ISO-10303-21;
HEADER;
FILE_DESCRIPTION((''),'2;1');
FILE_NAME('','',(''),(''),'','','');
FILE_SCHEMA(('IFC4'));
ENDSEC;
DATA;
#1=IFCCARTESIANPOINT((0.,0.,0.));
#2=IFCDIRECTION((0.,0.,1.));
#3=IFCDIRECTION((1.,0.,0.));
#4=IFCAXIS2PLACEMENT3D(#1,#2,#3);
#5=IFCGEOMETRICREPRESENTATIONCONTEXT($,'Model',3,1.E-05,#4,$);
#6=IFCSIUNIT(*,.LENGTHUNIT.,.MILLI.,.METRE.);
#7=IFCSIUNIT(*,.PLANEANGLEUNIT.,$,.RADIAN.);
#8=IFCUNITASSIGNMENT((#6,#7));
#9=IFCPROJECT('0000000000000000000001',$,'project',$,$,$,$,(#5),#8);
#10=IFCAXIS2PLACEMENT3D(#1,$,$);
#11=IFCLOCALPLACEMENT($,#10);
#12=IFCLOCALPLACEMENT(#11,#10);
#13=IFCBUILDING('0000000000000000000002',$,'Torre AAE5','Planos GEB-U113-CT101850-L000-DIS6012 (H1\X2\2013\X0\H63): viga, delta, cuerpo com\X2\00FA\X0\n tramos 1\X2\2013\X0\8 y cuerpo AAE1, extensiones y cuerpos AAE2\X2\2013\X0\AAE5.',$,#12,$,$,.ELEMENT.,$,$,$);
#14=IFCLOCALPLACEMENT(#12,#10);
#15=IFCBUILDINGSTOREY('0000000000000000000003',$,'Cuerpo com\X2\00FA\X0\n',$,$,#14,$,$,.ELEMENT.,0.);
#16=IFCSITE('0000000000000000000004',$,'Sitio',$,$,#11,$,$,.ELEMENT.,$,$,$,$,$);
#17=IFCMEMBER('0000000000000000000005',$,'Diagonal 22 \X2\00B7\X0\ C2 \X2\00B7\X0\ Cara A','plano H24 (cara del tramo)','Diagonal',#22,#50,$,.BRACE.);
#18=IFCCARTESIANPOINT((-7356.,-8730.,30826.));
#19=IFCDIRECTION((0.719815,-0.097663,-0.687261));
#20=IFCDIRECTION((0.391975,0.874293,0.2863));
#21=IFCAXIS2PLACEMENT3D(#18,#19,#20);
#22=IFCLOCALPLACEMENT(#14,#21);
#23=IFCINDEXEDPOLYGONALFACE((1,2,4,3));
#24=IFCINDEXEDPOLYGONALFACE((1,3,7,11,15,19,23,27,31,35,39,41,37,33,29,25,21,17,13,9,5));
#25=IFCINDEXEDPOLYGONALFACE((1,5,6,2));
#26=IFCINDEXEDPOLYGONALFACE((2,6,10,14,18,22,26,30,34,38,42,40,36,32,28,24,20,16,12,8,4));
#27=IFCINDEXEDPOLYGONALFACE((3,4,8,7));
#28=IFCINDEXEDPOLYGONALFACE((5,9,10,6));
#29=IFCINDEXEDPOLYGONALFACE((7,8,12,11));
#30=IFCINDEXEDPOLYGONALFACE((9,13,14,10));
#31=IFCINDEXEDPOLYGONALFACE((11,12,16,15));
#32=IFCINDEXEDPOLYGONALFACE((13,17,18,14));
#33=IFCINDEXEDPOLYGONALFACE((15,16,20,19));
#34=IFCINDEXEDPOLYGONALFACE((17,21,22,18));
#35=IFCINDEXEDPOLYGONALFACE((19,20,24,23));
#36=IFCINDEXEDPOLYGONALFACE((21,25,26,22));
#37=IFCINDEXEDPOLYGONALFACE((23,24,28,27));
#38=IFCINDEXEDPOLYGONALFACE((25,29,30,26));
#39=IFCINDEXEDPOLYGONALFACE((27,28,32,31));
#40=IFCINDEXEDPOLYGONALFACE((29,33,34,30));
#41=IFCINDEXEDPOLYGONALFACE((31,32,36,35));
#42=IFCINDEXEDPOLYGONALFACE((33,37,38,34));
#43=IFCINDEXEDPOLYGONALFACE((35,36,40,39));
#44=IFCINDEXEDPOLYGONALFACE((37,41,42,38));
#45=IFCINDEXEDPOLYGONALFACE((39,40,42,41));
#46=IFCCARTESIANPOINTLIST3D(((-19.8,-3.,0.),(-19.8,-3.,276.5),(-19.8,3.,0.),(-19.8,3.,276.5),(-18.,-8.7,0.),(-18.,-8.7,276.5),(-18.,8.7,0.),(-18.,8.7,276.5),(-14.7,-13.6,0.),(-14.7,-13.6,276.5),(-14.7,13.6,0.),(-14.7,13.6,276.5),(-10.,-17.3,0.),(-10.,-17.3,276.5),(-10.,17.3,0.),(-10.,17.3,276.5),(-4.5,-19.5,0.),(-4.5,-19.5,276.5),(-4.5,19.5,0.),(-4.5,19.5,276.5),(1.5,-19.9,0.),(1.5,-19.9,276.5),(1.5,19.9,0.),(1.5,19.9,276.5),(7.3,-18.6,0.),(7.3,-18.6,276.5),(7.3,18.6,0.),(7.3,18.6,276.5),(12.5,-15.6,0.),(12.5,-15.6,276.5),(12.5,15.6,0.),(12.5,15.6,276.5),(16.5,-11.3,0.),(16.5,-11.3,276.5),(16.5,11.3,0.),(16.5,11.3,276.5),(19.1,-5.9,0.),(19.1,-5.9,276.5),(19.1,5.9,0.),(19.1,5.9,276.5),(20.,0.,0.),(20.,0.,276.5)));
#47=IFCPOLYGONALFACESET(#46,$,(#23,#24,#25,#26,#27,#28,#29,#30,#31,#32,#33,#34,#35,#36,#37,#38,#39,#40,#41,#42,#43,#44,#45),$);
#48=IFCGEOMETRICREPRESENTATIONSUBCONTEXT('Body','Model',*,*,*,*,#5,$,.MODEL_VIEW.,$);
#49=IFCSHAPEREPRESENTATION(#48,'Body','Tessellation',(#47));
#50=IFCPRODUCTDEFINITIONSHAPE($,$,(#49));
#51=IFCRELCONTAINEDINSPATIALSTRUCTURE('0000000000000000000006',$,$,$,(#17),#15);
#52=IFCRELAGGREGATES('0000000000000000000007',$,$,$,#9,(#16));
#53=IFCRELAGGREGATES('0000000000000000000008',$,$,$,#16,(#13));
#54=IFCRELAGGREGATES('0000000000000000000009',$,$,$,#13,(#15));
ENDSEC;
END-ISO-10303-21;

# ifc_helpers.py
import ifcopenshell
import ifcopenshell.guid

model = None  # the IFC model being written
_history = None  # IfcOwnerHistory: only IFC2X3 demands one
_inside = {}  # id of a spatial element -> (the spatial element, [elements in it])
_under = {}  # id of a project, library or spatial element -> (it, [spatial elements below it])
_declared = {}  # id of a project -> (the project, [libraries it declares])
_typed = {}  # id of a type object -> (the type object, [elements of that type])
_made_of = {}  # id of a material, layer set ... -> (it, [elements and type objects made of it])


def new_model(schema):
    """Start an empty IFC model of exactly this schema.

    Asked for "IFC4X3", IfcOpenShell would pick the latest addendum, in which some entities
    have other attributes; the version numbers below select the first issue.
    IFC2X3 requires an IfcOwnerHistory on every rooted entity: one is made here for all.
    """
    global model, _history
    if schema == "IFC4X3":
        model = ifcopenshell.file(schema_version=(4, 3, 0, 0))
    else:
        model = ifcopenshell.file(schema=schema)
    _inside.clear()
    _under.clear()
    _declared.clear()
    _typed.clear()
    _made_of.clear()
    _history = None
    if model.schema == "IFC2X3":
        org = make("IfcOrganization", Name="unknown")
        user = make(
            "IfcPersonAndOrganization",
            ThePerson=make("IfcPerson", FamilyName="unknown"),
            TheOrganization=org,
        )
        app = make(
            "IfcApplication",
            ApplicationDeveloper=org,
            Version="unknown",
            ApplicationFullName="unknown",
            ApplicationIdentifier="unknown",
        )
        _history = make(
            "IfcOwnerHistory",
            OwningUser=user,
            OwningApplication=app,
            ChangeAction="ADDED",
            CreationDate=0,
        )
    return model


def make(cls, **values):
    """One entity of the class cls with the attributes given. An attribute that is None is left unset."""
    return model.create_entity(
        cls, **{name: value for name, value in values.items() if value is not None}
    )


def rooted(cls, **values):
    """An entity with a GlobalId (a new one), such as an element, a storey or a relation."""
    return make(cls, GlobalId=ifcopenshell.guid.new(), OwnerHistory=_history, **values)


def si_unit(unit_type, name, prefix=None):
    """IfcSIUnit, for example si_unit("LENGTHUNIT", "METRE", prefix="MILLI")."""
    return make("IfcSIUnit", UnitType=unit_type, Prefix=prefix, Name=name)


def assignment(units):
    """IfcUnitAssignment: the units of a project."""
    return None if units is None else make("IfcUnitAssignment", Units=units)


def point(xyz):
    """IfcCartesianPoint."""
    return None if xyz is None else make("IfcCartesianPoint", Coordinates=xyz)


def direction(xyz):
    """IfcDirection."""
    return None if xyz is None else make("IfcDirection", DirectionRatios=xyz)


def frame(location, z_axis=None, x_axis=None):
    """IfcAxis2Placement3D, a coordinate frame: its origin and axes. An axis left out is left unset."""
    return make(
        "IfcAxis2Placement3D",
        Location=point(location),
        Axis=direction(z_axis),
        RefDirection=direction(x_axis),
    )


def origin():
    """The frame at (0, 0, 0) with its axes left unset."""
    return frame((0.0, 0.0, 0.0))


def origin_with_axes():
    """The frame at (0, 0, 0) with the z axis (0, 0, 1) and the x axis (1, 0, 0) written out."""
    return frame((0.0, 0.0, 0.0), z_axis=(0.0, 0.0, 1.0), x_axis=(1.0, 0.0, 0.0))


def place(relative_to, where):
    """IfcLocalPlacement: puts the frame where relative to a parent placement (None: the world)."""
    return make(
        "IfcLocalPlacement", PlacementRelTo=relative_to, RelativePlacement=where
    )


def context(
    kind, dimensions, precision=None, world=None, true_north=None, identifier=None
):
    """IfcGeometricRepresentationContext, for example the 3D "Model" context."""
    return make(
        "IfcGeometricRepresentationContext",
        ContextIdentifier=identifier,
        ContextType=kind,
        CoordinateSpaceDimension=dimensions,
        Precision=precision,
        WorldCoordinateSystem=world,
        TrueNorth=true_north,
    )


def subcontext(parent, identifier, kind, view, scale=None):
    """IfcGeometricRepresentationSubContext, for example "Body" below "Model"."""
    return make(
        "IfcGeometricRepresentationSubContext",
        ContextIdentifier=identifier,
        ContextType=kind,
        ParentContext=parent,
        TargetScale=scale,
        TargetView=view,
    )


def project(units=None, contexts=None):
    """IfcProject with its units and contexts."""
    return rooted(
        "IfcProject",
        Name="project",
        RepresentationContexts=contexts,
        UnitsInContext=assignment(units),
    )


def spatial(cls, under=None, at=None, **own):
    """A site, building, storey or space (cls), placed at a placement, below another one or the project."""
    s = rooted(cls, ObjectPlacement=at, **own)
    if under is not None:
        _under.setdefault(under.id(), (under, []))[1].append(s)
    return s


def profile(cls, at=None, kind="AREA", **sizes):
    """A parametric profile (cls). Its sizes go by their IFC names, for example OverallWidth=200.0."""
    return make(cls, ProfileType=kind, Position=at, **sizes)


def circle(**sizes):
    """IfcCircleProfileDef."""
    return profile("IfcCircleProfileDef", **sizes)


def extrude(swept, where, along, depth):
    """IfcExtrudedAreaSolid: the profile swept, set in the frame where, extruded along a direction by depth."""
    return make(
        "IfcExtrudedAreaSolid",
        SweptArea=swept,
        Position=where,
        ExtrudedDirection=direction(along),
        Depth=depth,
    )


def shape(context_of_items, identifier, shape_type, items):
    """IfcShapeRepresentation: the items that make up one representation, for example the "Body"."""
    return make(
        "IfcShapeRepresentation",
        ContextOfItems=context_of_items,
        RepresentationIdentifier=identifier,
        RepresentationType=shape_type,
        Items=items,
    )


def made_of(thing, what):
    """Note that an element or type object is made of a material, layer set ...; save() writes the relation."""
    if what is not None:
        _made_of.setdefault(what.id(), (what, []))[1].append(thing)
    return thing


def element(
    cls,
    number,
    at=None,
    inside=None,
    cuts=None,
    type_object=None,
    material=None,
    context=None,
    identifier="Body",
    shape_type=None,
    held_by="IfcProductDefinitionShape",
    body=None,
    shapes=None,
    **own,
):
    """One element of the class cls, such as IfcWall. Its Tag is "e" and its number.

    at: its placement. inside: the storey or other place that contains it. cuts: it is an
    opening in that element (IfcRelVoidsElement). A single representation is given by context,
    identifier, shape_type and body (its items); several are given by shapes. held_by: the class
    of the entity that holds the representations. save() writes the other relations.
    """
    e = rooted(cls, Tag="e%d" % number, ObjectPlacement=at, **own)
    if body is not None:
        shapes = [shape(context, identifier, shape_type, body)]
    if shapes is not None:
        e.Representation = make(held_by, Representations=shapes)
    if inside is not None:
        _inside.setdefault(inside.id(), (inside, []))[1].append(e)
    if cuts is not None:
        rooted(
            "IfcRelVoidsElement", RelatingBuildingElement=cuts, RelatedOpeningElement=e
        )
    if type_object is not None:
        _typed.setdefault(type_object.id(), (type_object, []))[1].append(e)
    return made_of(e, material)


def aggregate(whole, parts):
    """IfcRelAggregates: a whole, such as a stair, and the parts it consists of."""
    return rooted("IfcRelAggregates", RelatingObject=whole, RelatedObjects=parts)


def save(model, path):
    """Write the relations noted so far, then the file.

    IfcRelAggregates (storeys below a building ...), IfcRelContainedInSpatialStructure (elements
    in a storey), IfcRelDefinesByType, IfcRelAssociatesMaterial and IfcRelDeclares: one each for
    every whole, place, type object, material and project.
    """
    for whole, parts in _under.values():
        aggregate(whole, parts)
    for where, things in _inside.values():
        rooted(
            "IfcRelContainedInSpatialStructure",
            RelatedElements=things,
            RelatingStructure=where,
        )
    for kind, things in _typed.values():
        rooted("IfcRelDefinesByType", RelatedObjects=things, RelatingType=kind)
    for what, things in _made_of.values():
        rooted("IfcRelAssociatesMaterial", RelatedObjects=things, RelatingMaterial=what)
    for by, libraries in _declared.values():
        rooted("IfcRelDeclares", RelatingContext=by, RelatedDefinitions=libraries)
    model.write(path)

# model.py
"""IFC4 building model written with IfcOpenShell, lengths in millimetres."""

from ifc_helpers import new_model, si_unit, frame, origin, origin_with_axes, place, context, subcontext, project, spatial, circle, extrude, element, save


model = new_model("IFC4")

# Units and contexts
model_context = context("Model", 3, precision=1e-05, world=origin_with_axes())
body_context = subcontext(model_context, "Body", "Model", "MODEL_VIEW")
ifc_project = project(units=[si_unit("LENGTHUNIT", "METRE", prefix="MILLI"), si_unit("PLANEANGLEUNIT", "RADIAN")], contexts=[model_context])

# Site, building, storey
site_placement = place(None, origin())
site = spatial("IfcSite", under=ifc_project, at=site_placement, Name="Sitio", CompositionType="ELEMENT")
building_placement = place(site_placement, origin())
building = spatial("IfcBuilding", under=site, at=building_placement, Name="Torre AAE5", Description="Planos GEB-U113-CT101850-L000-DIS6012 (H1–H63): viga, delta, cuerpo común tramos 1–8 y cuerpo AAE1, extensiones y cuerpos AAE2–AAE5.", CompositionType="ELEMENT")
storey_placement = place(building_placement, origin())
storey = spatial("IfcBuildingStorey", under=building, at=storey_placement, Name="Cuerpo común", CompositionType="ELEMENT", Elevation=0.0)

# Member
member_1_placement = place(storey_placement, frame((-7356.0, -8730.0, 30826.0), z_axis=(0.719815, -0.097663, -0.687261), x_axis=(0.391975, 0.874293, 0.2863)))
element("IfcMember", 1, at=member_1_placement, inside=storey, Name="Diagonal 22 · C2 · Cara A", Description="plano H24 (cara del tramo)", ObjectType="Diagonal", PredefinedType="BRACE", context=body_context, shape_type="SweptSolid", body=[
    extrude(circle(Radius=20.0), None, (0.0, 0.0, 1.0), 276.5),
])

save(model, "model.ifc")
